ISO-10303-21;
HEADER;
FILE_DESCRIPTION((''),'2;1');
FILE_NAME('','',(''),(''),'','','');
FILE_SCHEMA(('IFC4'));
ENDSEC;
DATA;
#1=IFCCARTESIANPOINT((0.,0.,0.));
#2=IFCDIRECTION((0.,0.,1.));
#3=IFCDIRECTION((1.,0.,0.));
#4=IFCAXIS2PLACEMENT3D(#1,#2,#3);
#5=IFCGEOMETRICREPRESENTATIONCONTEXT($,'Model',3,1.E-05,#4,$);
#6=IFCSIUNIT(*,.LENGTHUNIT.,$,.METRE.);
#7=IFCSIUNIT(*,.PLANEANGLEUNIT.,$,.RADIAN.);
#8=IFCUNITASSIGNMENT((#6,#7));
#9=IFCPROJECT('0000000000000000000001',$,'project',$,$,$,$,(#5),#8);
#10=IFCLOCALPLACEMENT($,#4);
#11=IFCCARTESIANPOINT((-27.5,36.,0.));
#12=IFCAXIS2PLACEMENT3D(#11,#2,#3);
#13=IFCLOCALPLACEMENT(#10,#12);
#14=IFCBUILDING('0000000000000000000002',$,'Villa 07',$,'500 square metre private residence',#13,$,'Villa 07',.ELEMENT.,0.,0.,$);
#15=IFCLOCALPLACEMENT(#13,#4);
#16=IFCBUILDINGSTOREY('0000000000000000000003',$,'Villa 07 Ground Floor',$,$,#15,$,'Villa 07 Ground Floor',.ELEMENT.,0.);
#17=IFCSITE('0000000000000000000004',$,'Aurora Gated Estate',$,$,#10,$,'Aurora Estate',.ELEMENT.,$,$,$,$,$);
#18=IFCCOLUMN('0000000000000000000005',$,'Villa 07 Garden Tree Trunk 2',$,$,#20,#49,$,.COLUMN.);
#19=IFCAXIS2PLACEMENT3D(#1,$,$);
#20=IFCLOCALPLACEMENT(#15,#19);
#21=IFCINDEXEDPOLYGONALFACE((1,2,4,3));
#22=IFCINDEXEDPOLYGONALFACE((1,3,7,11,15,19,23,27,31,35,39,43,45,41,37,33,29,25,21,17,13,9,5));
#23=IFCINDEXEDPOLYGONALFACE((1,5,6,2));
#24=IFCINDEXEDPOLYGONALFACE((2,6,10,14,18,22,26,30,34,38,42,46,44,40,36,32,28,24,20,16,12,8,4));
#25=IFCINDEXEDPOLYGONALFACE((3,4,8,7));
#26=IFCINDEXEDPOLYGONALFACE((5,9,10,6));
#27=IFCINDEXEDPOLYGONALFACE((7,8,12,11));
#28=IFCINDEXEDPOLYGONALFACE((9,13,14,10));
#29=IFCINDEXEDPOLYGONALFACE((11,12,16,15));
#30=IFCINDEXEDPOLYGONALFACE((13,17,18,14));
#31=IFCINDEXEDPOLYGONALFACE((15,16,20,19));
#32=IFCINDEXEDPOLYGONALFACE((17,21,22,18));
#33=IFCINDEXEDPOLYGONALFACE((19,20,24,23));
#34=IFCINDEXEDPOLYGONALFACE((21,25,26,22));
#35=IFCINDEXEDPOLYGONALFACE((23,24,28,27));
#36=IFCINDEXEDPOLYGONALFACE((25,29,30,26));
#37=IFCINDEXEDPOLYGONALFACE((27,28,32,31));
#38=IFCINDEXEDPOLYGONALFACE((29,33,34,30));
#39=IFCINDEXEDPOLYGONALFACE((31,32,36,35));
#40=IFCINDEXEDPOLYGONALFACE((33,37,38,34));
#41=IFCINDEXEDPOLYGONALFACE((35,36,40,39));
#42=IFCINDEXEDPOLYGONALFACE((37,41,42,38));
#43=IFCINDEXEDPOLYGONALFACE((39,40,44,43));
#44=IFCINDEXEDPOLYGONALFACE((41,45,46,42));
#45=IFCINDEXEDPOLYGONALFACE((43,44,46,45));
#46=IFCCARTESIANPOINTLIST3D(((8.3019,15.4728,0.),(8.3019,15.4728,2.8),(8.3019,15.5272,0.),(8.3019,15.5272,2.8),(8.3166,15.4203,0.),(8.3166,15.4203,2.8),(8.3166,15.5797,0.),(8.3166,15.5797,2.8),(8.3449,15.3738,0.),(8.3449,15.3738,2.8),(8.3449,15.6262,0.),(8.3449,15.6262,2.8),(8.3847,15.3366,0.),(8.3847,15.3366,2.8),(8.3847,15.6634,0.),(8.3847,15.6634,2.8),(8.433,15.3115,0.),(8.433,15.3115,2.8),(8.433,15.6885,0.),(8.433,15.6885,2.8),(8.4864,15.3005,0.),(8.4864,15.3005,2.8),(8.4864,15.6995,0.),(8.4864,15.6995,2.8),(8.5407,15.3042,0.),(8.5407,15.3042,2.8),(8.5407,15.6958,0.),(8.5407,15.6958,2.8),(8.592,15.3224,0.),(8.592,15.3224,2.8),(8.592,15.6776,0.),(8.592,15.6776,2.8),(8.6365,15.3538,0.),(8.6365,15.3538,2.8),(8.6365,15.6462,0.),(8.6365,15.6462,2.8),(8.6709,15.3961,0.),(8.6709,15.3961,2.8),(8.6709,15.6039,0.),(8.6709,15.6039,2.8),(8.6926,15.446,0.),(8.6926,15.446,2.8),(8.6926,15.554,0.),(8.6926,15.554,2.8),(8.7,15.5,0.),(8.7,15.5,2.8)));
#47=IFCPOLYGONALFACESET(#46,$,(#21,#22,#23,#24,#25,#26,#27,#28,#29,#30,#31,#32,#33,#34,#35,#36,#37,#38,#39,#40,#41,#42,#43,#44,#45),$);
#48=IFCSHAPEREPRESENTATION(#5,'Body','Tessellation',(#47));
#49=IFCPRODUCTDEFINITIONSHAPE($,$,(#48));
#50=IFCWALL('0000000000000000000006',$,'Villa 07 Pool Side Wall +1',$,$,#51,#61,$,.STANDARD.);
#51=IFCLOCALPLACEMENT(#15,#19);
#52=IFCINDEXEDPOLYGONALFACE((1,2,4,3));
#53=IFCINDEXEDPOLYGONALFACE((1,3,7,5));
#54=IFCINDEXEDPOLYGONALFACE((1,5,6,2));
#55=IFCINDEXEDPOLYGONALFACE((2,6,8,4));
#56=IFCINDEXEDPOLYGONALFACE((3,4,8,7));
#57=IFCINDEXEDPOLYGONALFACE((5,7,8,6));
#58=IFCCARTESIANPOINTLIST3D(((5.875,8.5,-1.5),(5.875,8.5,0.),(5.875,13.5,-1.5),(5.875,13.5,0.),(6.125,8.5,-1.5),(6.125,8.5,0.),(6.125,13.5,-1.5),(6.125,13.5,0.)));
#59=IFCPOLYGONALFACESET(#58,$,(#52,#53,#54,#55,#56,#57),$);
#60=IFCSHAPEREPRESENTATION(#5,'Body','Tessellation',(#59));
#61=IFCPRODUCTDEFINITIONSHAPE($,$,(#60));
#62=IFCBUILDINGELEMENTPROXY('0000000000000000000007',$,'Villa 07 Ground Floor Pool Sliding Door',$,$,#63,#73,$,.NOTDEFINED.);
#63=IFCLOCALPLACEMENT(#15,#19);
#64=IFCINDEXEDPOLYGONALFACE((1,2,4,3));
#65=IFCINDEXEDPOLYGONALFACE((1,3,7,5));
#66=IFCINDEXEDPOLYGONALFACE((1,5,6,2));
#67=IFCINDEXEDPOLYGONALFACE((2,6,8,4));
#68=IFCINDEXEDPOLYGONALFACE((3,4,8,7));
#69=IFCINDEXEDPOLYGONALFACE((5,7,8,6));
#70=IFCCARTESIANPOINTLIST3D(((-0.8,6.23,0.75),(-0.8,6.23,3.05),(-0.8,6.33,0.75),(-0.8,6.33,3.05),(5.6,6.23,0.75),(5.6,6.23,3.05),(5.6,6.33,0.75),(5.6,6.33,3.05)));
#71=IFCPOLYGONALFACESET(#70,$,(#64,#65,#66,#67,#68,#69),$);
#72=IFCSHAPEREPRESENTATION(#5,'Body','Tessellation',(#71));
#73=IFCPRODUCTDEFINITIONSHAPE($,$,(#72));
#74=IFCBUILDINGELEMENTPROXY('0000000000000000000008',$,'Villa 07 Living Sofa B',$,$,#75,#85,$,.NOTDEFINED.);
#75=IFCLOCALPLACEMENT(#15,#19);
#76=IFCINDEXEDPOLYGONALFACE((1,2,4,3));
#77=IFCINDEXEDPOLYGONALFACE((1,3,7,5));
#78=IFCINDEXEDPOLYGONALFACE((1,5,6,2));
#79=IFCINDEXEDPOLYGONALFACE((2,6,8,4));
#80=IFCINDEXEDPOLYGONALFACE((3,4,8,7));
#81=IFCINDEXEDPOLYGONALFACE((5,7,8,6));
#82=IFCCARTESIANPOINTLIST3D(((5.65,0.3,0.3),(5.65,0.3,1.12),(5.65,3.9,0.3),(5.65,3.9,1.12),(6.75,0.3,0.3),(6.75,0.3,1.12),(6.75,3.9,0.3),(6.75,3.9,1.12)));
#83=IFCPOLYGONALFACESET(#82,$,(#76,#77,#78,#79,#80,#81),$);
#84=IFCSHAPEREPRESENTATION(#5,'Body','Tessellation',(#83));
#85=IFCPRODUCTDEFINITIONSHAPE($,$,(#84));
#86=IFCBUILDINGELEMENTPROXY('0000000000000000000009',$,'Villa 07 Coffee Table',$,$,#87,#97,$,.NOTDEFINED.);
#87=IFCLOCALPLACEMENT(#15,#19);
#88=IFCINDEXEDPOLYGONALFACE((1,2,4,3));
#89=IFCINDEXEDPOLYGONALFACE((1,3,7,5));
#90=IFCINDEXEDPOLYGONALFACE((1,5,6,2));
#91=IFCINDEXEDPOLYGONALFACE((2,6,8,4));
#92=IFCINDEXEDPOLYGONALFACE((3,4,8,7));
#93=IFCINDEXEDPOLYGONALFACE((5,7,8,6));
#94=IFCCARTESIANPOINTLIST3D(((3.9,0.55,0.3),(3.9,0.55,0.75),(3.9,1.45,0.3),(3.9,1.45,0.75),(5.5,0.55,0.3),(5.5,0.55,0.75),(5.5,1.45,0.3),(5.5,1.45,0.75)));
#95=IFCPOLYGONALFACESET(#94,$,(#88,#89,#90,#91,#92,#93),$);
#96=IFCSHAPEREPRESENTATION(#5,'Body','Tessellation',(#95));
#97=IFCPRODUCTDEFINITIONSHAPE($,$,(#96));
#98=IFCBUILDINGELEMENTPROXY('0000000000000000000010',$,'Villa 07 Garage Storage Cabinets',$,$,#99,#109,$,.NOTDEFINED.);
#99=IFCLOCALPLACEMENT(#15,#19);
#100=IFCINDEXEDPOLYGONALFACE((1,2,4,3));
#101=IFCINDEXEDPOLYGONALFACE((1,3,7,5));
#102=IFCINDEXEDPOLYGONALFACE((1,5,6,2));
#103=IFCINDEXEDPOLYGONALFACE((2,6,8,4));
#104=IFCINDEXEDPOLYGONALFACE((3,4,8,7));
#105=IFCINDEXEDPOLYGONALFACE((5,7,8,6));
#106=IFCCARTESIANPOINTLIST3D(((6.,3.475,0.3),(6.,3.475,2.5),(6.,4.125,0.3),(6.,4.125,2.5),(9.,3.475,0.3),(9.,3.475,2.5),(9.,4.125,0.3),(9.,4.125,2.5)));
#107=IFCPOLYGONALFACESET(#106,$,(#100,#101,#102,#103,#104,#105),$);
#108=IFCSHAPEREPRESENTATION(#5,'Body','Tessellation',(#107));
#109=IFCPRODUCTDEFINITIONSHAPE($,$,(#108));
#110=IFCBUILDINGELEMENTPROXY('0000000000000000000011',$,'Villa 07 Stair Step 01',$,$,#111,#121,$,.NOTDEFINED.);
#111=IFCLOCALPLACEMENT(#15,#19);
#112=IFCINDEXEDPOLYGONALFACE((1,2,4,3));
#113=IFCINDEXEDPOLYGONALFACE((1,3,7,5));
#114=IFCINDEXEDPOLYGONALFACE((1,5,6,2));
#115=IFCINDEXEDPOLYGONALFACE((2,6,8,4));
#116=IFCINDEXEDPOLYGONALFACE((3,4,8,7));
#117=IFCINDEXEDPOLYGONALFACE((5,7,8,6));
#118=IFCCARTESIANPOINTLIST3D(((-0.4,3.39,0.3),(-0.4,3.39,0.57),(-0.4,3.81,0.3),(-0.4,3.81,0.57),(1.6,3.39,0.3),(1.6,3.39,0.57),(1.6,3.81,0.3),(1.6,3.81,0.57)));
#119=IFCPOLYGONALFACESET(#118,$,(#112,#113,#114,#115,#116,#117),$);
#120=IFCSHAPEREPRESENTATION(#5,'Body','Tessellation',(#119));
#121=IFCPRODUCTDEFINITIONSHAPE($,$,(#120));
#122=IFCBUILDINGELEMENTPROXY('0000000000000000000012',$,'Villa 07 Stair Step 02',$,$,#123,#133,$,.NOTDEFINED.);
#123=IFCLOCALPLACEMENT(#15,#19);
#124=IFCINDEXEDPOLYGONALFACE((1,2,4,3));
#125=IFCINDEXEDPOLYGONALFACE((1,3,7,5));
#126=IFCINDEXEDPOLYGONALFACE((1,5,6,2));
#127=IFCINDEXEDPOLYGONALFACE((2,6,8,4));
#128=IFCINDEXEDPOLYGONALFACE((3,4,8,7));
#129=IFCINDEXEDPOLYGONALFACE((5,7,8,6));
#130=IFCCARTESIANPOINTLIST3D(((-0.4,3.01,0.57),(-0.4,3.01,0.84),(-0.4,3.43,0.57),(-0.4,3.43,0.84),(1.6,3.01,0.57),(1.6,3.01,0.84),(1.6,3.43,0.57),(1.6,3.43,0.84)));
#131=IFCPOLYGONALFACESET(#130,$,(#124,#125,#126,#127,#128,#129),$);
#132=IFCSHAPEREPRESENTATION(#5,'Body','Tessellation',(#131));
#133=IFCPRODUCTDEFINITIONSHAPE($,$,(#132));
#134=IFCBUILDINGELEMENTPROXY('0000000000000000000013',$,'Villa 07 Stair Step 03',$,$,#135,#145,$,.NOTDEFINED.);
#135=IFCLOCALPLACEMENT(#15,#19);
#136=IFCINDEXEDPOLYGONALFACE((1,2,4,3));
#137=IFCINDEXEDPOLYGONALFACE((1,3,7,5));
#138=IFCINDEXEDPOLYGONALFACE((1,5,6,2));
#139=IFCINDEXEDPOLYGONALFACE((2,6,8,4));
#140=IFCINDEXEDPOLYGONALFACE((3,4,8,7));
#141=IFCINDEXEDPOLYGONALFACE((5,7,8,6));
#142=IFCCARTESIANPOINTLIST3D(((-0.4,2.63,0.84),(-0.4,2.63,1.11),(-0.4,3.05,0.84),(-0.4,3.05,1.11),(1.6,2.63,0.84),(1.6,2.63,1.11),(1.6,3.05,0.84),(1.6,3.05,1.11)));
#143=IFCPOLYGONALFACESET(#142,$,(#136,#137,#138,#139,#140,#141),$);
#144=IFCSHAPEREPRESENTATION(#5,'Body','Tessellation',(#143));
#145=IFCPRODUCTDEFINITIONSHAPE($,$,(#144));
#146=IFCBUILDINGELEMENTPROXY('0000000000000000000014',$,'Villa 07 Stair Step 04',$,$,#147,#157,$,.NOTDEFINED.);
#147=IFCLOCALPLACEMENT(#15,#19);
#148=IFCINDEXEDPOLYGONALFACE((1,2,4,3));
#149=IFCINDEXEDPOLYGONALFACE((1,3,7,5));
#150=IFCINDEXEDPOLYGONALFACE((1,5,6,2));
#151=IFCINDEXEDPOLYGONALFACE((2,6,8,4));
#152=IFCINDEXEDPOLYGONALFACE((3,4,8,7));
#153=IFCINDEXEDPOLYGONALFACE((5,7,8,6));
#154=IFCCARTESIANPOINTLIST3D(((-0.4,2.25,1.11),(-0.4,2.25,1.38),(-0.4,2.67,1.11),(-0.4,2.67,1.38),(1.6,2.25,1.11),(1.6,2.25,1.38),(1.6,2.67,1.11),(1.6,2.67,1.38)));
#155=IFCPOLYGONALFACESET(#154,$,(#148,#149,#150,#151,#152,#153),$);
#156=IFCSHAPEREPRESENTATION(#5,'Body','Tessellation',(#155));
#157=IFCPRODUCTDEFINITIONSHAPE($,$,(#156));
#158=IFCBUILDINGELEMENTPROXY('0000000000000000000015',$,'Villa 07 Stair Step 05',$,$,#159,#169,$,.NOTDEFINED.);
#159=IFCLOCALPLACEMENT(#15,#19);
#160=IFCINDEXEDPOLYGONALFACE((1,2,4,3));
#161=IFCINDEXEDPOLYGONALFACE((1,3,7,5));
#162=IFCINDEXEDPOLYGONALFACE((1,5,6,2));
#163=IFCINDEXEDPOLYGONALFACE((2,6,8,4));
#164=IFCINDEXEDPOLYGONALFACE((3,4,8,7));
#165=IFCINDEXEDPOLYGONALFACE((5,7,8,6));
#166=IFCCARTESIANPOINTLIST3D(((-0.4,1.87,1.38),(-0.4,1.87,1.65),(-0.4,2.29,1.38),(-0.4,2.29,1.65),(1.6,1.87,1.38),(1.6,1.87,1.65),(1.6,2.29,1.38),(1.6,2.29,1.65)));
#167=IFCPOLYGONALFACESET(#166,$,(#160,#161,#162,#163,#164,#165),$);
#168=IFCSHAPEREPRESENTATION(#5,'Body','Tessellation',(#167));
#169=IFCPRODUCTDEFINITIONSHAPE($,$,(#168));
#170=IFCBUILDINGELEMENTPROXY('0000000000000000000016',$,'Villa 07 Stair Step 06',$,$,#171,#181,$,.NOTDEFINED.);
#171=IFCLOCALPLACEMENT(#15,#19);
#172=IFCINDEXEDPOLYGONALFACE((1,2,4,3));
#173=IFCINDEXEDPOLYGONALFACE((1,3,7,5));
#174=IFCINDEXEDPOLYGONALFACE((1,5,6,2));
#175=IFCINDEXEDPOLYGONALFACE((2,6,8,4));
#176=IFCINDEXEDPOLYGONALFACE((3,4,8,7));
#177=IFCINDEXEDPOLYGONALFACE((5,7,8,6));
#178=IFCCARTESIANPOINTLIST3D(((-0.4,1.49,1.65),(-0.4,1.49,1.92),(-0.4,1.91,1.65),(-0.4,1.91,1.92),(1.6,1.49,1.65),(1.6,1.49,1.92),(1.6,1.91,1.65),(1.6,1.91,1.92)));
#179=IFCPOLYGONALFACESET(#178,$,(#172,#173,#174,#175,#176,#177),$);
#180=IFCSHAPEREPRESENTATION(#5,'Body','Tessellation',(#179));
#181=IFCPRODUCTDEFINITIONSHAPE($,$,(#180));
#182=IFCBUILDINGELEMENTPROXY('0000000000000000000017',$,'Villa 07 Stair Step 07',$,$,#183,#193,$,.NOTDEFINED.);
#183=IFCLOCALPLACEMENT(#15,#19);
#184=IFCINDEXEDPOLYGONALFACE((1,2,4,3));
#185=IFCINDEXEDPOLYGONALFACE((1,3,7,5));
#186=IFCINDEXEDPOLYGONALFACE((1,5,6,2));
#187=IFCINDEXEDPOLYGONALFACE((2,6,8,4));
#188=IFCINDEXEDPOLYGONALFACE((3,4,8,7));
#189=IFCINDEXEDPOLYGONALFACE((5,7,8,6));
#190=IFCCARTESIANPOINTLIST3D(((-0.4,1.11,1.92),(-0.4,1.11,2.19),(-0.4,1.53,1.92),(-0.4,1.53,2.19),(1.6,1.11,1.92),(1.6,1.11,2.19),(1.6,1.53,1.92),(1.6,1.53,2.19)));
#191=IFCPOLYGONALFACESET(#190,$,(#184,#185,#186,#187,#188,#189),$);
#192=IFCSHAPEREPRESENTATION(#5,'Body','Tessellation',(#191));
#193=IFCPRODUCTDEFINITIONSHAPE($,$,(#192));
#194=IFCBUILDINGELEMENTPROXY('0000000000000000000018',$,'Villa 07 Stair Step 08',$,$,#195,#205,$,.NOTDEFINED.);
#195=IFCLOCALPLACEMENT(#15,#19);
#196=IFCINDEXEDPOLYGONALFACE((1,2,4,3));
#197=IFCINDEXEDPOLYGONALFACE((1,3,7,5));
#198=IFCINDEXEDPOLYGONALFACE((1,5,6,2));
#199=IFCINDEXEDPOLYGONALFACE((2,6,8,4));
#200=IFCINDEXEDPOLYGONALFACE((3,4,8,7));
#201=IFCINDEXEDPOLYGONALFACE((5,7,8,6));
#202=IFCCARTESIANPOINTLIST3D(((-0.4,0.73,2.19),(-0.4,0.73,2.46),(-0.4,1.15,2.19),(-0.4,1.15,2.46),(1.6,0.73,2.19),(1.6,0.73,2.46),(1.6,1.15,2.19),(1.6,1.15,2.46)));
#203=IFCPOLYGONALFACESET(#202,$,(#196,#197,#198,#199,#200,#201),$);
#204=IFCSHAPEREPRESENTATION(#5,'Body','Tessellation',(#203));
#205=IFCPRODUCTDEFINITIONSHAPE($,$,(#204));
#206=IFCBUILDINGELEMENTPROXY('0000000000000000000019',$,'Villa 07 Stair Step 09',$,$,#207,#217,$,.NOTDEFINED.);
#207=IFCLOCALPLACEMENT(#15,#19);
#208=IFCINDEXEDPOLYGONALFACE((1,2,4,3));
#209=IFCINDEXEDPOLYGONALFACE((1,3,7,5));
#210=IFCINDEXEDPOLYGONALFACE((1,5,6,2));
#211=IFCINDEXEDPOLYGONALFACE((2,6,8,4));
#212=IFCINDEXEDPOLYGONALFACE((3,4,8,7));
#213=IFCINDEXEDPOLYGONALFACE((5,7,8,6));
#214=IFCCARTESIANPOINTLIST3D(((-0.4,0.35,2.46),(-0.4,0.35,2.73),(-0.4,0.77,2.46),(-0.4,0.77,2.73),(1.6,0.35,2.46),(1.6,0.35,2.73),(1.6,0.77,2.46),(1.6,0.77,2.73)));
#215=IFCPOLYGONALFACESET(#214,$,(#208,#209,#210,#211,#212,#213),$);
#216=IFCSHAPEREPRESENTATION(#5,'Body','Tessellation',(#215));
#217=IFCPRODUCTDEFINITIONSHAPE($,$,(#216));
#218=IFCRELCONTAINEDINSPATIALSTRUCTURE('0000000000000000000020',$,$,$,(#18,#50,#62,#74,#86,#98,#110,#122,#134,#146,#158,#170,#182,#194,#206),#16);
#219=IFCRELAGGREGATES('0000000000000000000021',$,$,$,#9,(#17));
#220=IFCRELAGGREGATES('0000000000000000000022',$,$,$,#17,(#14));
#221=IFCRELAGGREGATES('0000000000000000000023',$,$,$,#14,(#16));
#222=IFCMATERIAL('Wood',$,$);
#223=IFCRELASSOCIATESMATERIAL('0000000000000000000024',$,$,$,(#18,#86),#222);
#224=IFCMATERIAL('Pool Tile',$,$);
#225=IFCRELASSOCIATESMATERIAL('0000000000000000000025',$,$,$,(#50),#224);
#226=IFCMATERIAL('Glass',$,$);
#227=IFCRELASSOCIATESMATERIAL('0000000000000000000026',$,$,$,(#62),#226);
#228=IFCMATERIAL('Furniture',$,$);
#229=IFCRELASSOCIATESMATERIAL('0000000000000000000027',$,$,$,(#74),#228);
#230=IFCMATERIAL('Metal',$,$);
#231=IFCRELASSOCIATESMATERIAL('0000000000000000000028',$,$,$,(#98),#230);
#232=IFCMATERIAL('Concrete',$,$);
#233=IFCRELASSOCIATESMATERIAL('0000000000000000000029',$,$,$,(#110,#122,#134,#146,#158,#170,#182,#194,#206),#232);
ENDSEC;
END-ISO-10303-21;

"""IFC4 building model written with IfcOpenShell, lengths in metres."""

from ifc_helpers import new_model, si_unit, frame, origin_with_axes, origin_2d_with_axis, place, context, project, spatial, rectangle, circle, extrude, material, element, save


model = new_model("IFC4")

# Units and contexts
model_context = context("Model", 3, precision=1e-05, world=origin_with_axes())
ifc_project = project(units=[si_unit("LENGTHUNIT", "METRE"), si_unit("PLANEANGLEUNIT", "RADIAN")], contexts=[model_context])

# Site, building, storey
site_placement = place(None, origin_with_axes())
site = spatial("IfcSite", under=ifc_project, at=site_placement, Name="Aurora Gated Estate", LongName="Aurora Estate", CompositionType="ELEMENT")
building_placement = place(site_placement, frame((-27.5, 36.0, 0.0), z_axis=(0.0, 0.0, 1.0), x_axis=(1.0, 0.0, 0.0)))
building = spatial("IfcBuilding", under=site, at=building_placement, Name="Villa 07", ObjectType="500 square metre private residence", LongName="Villa 07", CompositionType="ELEMENT", ElevationOfRefHeight=0.0, ElevationOfTerrain=0.0)
storey_placement = place(building_placement, origin_with_axes())
storey = spatial("IfcBuildingStorey", under=building, at=storey_placement, Name="Villa 07 Ground Floor", LongName="Villa 07 Ground Floor", CompositionType="ELEMENT", Elevation=0.0)

# Column
ifc_material_1 = material(Name="Wood")
column_placement = place(storey_placement, frame((8.5, 15.5, 0.0), z_axis=(0.0, 0.0, 1.0), x_axis=(1.0, 0.0, 0.0)))
element("IfcColumn", 1, at=column_placement, inside=storey, material=ifc_material_1, Name="Villa 07 Garden Tree Trunk 2", PredefinedType="COLUMN", context=model_context, shape_type="SweptSolid", body=[
    extrude(circle(Radius=0.2, at=origin_2d_with_axis()), origin_with_axes(), (0.0, 0.0, 1.0), 2.8),
])

# Wall
ifc_material_2 = material(Name="Pool Tile")
wall_placement = place(storey_placement, frame((6.0, 11.0, -1.5), z_axis=(0.0, 0.0, 1.0), x_axis=(1.0, 0.0, 0.0)))
element("IfcWall", 2, at=wall_placement, inside=storey, material=ifc_material_2, Name="Villa 07 Pool Side Wall +1", PredefinedType="STANDARD", context=model_context, shape_type="SweptSolid", body=[
    extrude(rectangle(XDim=0.25, YDim=5.0, at=origin_2d_with_axis()), origin_with_axes(), (0.0, 0.0, 1.0), 1.5),
])

# Building element proxies
ifc_material_3 = material(Name="Glass")
proxy_1_placement = place(storey_placement, frame((2.4, 6.28, 0.75), z_axis=(0.0, 0.0, 1.0), x_axis=(1.0, 0.0, 0.0)))
element("IfcBuildingElementProxy", 3, at=proxy_1_placement, inside=storey, material=ifc_material_3, Name="Villa 07 Ground Floor Pool Sliding Door", PredefinedType="NOTDEFINED", context=model_context, shape_type="SweptSolid", body=[
    extrude(rectangle(XDim=6.4, YDim=0.1, at=origin_2d_with_axis()), origin_with_axes(), (0.0, 0.0, 1.0), 2.3),
])
ifc_material_4 = material(Name="Furniture")
proxy_2_placement = place(storey_placement, frame((6.2, 2.1, 0.3), z_axis=(0.0, 0.0, 1.0), x_axis=(1.0, 0.0, 0.0)))
element("IfcBuildingElementProxy", 4, at=proxy_2_placement, inside=storey, material=ifc_material_4, Name="Villa 07 Living Sofa B", PredefinedType="NOTDEFINED", context=model_context, shape_type="SweptSolid", body=[
    extrude(rectangle(XDim=1.1, YDim=3.6, at=origin_2d_with_axis()), origin_with_axes(), (0.0, 0.0, 1.0), 0.82),
])
proxy_3_placement = place(storey_placement, frame((4.7, 1.0, 0.3), z_axis=(0.0, 0.0, 1.0), x_axis=(1.0, 0.0, 0.0)))
element("IfcBuildingElementProxy", 5, at=proxy_3_placement, inside=storey, material=ifc_material_1, Name="Villa 07 Coffee Table", PredefinedType="NOTDEFINED", context=model_context, shape_type="SweptSolid", body=[
    extrude(rectangle(XDim=1.6, YDim=0.9, at=origin_2d_with_axis()), origin_with_axes(), (0.0, 0.0, 1.0), 0.45),
])
ifc_material_5 = material(Name="Metal")
proxy_4_placement = place(storey_placement, frame((7.5, 3.8, 0.3), z_axis=(0.0, 0.0, 1.0), x_axis=(1.0, 0.0, 0.0)))
element("IfcBuildingElementProxy", 6, at=proxy_4_placement, inside=storey, material=ifc_material_5, Name="Villa 07 Garage Storage Cabinets", PredefinedType="NOTDEFINED", context=model_context, shape_type="SweptSolid", body=[
    extrude(rectangle(XDim=3.0, YDim=0.65, at=origin_2d_with_axis()), origin_with_axes(), (0.0, 0.0, 1.0), 2.2),
])
ifc_material_6 = material(Name="Concrete")
for number, where, z_axis, x_axis, name in (
    (7, (0.6, 3.6, 0.3), (0.0, 0.0, 1.0), (1.0, 0.0, 0.0), "Villa 07 Stair Step 01"),
    (8, (0.6, 3.22, 0.57), (0.0, 0.0, 1.0), (1.0, 0.0, 0.0), "Villa 07 Stair Step 02"),
    (9, (0.6, 2.84, 0.84), (0.0, 0.0, 1.0), (1.0, 0.0, 0.0), "Villa 07 Stair Step 03"),
    (10, (0.6, 2.46, 1.11), (0.0, 0.0, 1.0), (1.0, 0.0, 0.0), "Villa 07 Stair Step 04"),
    (11, (0.6, 2.08, 1.38), (0.0, 0.0, 1.0), (1.0, 0.0, 0.0), "Villa 07 Stair Step 05"),
    (12, (0.6, 1.7, 1.65), (0.0, 0.0, 1.0), (1.0, 0.0, 0.0), "Villa 07 Stair Step 06"),
    (13, (0.6, 1.32, 1.92), (0.0, 0.0, 1.0), (1.0, 0.0, 0.0), "Villa 07 Stair Step 07"),
    (14, (0.6, 0.94, 2.19), (0.0, 0.0, 1.0), (1.0, 0.0, 0.0), "Villa 07 Stair Step 08"),
    (15, (0.6, 0.56, 2.46), (0.0, 0.0, 1.0), (1.0, 0.0, 0.0), "Villa 07 Stair Step 09"),
):
    element("IfcBuildingElementProxy", number, at=place(storey_placement, frame(where, z_axis=z_axis, x_axis=x_axis)), inside=storey, material=ifc_material_6, Name=name, PredefinedType="NOTDEFINED", context=model_context, shape_type="SweptSolid", body=[
        extrude(rectangle(XDim=2.0, YDim=0.42, at=origin_2d_with_axis()), origin_with_axes(), (0.0, 0.0, 1.0), 0.27),
    ])

save(model, "model.ifc")
